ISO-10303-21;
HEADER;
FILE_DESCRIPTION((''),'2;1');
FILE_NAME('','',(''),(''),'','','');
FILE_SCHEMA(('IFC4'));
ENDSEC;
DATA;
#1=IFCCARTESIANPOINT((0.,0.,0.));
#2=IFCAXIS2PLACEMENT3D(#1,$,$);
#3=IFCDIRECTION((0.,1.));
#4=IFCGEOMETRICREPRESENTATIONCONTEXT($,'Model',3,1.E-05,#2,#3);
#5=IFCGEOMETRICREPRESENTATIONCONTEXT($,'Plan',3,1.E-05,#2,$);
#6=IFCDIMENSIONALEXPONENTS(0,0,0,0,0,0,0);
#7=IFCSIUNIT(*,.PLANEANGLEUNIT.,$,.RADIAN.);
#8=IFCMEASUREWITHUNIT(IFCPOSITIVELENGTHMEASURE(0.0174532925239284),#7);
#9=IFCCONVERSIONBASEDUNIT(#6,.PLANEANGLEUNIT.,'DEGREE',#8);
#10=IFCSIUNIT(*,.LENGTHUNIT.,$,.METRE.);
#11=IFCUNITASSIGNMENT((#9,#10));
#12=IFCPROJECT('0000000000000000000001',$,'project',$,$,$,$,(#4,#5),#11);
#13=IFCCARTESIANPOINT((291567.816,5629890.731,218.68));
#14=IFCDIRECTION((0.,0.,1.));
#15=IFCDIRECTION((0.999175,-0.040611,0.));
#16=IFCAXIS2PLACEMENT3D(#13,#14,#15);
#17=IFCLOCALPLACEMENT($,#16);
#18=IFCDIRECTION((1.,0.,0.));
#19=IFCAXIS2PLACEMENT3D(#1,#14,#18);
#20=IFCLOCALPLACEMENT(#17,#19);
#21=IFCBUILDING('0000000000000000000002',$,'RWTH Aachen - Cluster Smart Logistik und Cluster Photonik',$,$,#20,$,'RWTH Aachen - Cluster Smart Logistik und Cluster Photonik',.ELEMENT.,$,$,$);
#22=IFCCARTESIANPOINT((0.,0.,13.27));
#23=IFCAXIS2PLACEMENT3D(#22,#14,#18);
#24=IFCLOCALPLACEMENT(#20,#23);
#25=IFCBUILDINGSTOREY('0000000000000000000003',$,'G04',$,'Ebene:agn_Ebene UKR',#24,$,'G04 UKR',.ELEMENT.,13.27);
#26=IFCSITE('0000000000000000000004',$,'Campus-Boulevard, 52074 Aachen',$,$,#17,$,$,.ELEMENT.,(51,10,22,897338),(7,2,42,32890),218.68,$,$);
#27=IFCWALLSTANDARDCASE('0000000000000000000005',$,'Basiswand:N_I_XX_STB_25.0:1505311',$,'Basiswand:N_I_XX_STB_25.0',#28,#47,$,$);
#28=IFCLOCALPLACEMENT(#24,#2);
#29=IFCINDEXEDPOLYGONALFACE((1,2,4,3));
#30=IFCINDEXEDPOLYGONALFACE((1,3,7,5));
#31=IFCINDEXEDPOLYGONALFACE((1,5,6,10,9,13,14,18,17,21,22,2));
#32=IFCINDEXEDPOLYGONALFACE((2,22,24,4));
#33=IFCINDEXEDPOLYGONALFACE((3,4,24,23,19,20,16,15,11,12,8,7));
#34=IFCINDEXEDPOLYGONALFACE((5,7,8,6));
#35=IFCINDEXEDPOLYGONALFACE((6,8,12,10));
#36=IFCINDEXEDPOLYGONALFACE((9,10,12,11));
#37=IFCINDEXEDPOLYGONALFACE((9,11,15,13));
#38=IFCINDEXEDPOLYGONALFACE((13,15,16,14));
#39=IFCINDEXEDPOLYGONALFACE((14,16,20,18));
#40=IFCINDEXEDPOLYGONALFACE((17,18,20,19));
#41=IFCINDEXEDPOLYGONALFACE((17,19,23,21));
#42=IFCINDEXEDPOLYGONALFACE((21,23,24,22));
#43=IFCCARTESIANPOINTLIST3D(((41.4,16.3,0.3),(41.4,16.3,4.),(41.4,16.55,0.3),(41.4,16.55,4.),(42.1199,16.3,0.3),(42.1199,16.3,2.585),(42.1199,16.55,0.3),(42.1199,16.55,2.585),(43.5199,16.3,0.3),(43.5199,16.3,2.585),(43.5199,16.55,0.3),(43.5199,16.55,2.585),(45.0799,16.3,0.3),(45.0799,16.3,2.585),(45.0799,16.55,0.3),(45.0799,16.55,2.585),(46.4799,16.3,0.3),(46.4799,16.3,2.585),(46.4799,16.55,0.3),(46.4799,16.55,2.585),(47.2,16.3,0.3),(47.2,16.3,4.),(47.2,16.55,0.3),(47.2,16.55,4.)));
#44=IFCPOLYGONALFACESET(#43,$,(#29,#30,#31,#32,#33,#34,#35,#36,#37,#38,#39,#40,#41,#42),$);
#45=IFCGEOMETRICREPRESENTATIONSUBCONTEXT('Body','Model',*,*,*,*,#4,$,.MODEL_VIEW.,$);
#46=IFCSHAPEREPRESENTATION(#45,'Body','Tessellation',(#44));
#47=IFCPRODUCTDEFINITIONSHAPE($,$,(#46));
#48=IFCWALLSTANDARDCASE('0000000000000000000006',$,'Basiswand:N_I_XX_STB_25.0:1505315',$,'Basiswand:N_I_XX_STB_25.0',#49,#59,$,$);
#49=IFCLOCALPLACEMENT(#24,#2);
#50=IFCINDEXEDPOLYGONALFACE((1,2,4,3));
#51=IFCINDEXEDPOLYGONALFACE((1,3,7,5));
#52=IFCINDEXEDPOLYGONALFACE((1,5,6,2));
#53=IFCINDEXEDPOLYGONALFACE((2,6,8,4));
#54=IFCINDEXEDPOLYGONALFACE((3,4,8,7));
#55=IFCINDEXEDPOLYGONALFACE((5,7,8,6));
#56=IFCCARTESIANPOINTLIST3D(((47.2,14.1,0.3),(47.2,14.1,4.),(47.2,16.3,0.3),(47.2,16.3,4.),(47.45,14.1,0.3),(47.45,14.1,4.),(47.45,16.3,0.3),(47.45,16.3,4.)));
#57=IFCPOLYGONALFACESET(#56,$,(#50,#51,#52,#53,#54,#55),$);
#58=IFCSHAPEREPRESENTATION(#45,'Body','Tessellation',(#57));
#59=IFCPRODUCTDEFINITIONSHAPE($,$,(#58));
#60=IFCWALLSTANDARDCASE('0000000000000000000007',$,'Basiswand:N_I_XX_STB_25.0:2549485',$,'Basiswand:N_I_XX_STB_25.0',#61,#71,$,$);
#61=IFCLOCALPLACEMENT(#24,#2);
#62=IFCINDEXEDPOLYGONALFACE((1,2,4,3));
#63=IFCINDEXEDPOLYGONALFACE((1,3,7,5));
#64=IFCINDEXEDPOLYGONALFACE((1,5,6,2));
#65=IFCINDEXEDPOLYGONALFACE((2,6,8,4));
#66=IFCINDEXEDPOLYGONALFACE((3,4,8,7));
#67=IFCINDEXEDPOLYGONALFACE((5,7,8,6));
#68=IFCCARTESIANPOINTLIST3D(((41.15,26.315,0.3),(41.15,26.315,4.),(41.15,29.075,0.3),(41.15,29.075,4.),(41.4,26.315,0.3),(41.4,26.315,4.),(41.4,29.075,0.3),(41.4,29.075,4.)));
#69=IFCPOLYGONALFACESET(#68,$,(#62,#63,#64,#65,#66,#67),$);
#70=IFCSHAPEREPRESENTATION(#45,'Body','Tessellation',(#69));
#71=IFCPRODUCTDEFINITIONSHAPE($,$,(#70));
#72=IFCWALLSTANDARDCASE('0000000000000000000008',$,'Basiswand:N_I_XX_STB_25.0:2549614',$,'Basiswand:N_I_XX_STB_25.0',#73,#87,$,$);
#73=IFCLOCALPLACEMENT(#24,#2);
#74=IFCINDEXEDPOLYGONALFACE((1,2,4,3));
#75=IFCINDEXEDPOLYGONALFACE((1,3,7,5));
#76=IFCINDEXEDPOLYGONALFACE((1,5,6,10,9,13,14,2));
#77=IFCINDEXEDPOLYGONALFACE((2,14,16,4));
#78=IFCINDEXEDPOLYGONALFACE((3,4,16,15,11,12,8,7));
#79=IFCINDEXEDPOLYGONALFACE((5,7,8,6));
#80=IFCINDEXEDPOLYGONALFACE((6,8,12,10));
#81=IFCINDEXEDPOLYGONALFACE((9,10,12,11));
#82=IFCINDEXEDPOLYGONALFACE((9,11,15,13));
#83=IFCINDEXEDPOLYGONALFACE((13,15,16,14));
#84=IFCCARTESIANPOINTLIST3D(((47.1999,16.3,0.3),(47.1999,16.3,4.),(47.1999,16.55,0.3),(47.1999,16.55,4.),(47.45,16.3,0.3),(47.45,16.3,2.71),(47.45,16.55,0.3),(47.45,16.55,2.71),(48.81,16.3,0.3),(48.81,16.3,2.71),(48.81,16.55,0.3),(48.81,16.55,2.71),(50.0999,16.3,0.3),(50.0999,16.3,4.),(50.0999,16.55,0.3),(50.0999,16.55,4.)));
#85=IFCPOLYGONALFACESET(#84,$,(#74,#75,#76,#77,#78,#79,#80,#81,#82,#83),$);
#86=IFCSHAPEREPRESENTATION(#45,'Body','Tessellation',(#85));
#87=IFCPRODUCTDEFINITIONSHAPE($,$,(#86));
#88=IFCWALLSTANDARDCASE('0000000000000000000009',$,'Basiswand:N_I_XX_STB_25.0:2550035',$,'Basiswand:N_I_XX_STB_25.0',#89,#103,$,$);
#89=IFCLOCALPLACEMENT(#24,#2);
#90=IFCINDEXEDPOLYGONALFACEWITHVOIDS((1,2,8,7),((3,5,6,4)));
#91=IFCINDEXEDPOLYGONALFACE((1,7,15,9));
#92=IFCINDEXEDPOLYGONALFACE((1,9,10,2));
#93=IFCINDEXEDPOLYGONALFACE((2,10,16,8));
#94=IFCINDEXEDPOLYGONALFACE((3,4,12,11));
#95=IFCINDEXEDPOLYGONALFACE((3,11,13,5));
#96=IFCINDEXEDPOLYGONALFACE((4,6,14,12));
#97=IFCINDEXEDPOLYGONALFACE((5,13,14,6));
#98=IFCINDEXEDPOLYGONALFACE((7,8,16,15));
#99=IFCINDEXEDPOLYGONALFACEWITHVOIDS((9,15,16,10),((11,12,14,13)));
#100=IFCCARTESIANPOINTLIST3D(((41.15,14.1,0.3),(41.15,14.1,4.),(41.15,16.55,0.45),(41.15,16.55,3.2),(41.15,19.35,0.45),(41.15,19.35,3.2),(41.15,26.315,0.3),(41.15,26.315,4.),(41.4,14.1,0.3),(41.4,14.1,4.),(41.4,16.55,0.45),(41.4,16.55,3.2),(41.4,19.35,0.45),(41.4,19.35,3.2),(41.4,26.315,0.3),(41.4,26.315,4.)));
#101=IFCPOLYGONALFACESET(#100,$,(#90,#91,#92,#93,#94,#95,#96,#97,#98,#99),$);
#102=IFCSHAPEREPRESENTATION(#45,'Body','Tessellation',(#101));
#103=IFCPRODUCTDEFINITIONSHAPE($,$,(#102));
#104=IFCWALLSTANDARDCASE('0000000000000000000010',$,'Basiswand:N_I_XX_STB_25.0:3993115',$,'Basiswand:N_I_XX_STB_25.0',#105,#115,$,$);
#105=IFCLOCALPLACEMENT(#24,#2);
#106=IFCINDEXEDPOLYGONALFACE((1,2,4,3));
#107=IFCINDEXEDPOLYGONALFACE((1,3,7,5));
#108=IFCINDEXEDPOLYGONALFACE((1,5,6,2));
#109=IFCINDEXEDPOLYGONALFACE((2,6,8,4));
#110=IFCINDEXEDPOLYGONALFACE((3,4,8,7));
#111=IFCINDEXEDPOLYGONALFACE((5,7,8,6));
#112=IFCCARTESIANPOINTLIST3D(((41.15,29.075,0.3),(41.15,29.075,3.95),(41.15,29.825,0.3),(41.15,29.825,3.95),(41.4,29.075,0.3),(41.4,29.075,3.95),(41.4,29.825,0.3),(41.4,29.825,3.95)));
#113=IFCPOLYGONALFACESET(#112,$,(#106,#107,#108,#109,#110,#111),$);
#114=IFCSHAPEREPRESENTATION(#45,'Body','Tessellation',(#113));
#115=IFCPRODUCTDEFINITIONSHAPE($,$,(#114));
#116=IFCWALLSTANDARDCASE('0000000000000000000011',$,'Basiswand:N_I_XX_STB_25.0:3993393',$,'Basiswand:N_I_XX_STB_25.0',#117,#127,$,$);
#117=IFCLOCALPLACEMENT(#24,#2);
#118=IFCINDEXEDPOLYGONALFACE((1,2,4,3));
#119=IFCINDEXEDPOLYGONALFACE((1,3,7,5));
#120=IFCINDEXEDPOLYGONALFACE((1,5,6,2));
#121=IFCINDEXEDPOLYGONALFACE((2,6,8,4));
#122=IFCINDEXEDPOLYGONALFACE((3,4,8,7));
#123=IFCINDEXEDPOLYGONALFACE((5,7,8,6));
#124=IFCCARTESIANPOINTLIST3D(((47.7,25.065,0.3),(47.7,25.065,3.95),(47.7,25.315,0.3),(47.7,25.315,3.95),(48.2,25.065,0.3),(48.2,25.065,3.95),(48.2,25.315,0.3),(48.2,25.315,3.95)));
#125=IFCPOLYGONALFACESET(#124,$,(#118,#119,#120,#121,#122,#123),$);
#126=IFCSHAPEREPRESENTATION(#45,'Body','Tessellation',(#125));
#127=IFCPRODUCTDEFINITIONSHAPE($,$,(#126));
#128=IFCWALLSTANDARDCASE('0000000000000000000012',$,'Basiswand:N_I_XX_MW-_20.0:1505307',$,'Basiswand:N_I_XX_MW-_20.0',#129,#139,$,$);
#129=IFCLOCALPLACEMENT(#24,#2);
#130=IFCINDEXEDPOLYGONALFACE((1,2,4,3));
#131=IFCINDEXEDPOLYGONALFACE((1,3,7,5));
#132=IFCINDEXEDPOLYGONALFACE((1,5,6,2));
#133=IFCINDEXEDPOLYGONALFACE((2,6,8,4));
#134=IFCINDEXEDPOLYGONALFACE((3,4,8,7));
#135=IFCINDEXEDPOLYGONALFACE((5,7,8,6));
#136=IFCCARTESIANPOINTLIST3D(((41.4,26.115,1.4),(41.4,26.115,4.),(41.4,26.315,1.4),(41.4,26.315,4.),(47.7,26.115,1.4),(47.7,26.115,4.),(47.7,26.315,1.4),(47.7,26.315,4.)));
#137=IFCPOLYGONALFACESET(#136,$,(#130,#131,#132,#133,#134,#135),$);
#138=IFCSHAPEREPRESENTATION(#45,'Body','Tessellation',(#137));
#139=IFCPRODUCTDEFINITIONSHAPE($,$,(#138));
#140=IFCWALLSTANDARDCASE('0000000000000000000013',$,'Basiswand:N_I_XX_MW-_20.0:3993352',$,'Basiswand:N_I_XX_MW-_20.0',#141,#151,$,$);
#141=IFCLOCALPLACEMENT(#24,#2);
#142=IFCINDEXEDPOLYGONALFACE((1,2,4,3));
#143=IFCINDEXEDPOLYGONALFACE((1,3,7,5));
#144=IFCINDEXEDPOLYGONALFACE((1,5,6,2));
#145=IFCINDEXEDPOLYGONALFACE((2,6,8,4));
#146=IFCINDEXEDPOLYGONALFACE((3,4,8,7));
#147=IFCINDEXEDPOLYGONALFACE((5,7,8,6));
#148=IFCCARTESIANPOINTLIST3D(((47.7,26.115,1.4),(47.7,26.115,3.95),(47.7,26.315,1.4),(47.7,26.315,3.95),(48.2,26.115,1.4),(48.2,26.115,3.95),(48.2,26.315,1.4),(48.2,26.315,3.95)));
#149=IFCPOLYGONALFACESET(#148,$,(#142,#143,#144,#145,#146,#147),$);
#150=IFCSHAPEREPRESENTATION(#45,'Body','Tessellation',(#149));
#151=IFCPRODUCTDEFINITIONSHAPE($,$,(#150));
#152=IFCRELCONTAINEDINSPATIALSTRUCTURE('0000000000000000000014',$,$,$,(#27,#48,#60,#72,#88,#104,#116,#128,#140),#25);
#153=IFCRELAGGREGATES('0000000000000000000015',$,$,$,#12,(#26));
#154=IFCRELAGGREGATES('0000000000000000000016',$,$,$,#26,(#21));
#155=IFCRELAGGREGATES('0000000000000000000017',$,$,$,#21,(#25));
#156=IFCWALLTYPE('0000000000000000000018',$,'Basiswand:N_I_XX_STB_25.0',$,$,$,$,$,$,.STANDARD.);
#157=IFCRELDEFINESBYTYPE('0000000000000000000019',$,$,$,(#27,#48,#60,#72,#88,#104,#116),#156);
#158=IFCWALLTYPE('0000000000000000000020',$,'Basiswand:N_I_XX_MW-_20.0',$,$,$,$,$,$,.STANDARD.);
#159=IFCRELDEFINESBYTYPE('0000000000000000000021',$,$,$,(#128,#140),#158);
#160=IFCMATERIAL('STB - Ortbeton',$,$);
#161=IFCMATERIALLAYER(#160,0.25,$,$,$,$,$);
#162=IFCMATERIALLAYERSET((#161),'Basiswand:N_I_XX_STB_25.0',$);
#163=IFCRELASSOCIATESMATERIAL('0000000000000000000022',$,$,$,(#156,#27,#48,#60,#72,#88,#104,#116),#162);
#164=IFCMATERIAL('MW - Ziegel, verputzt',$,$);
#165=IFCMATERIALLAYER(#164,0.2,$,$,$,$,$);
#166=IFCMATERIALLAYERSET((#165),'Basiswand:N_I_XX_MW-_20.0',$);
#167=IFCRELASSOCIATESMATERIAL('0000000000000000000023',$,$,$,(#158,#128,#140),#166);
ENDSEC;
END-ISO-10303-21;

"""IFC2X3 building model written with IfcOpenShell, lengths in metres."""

from ifc_helpers import new_model, entity, si_unit, converted_unit, direction, frame, frame_2d, origin, origin_with_axes, place, context, subcontext, project, spatial, rectangle, extrude, material, layer, layer_set, layer_usage, type_object, element, save


model = new_model("IFC2X3")

# Units and contexts
model_context = context("Model", 3, precision=1e-05, world=origin(), true_north=direction((0.0, 1.0)))
plan_context = context("Plan", 3, precision=1e-05, world=origin())
body_context = subcontext(model_context, "Body", "Model", "MODEL_VIEW")
ifc_project = project(units=[converted_unit("PLANEANGLEUNIT", "DEGREE", entity("IfcPositiveLengthMeasure", 0.0174532925239284), si_unit("PLANEANGLEUNIT", "RADIAN"), dimensions=[0, 0, 0, 0, 0, 0, 0]), si_unit("LENGTHUNIT", "METRE")], contexts=[model_context, plan_context])

# Site, building, storey
site_placement = place(None, frame((291567.816, 5629890.731, 218.68), z_axis=(0.0, 0.0, 1.0), x_axis=(0.999175, -0.040611, 0.0)))
site = spatial("IfcSite", under=ifc_project, at=site_placement, Name="Campus-Boulevard, 52074 Aachen", CompositionType="ELEMENT", RefLatitude=(51, 10, 22, 897338), RefLongitude=(7, 2, 42, 32890), RefElevation=218.68)
building_placement = place(site_placement, origin_with_axes())
building = spatial("IfcBuilding", under=site, at=building_placement, Name="RWTH Aachen - Cluster Smart Logistik und Cluster Photonik", LongName="RWTH Aachen - Cluster Smart Logistik und Cluster Photonik", CompositionType="ELEMENT")
storey_placement = place(building_placement, frame((0.0, 0.0, 13.27), z_axis=(0.0, 0.0, 1.0), x_axis=(1.0, 0.0, 0.0)))
storey = spatial("IfcBuildingStorey", under=building, at=storey_placement, Name="G04", ObjectType="Ebene:agn_Ebene UKR", LongName="G04 UKR", CompositionType="ELEMENT", Elevation=13.27)

# Shared definitions
ifc_material_1 = material(Name="STB - Ortbeton")

# Shared definitions
ifc_layer_1 = layer(ifc_material_1, 0.25)
ifc_layer_set_1 = layer_set([ifc_layer_1], Name="Basiswand:N_I_XX_STB_25.0")
wall_type_1 = type_object("IfcWallType", Name="Basiswand:N_I_XX_STB_25.0", PredefinedType="STANDARD", material=ifc_layer_set_1)

# Wall, openings
ifc_layer_usage_1 = layer_usage(ifc_layer_set_1, "AXIS2", "NEGATIVE", 0.125)
wall_1_placement = place(storey_placement, frame((41.4, 16.425, 0.3), z_axis=(0.0, 0.0, 1.0), x_axis=(1.0, 0.0, 0.0)))
wall_1 = element("IfcWallStandardCase", 1, at=wall_1_placement, inside=storey, type_object=wall_type_1, material=ifc_layer_usage_1, Name="Basiswand:N_I_XX_STB_25.0:1505311", ObjectType="Basiswand:N_I_XX_STB_25.0", context=body_context, shape_type="SweptSolid", body=[
    extrude(rectangle(XDim=5.8, YDim=0.25, at=frame_2d((2.9, 0.0), x_axis=(-1.0, 0.0))), origin(), (0.0, 0.0, 1.0), 3.7),
])
opening_1_placement = place(wall_1_placement, frame((2.1199, 0.125, 0.0), z_axis=(0.0, 0.0, 1.0), x_axis=(1.0, 0.0, 0.0)))
element("IfcOpeningElement", 2, at=opening_1_placement, cuts=wall_1, ObjectType="Opening", context=body_context, shape_type="SweptSolid", body=[
    extrude(rectangle(XDim=2.285, YDim=1.4, at=frame_2d((1.1425, 0.7), x_axis=(1.0, 0.0))), frame((0.0, 0.0, 0.0), z_axis=(0.0, -1.0, 0.0), x_axis=(0.0, 0.0, 1.0)), (0.0, 0.0, 1.0), 0.25),
])
opening_2_placement = place(wall_1_placement, frame((5.0799, 0.125, 0.0), z_axis=(0.0, 0.0, 1.0), x_axis=(1.0, 0.0, 0.0)))
element("IfcOpeningElement", 3, at=opening_2_placement, cuts=wall_1, ObjectType="Opening", context=body_context, shape_type="SweptSolid", body=[
    extrude(rectangle(XDim=2.285, YDim=1.4, at=frame_2d((1.1425, 0.7), x_axis=(1.0, 0.0))), frame((0.0, 0.0, 0.0), z_axis=(0.0, -1.0, 0.0), x_axis=(0.0, 0.0, 1.0)), (0.0, 0.0, 1.0), 0.25),
])

# Walls
ifc_layer_usage_2 = layer_usage(ifc_layer_set_1, "AXIS2", "NEGATIVE", 0.125)
wall_2_placement = place(storey_placement, frame((47.325, 16.3, 0.3), z_axis=(0.0, 0.0, 1.0), x_axis=(0.0, -1.0, 0.0)))
element("IfcWallStandardCase", 4, at=wall_2_placement, inside=storey, type_object=wall_type_1, material=ifc_layer_usage_2, Name="Basiswand:N_I_XX_STB_25.0:1505315", ObjectType="Basiswand:N_I_XX_STB_25.0", context=body_context, shape_type="SweptSolid", body=[
    extrude(rectangle(XDim=2.2, YDim=0.25, at=frame_2d((1.1, 0.0), x_axis=(-1.0, 0.0))), origin(), (0.0, 0.0, 1.0), 3.7),
])
ifc_layer_usage_3 = layer_usage(ifc_layer_set_1, "AXIS2", "NEGATIVE", 0.125)
wall_3_placement = place(storey_placement, frame((41.275, 26.315, 0.3), z_axis=(0.0, 0.0, 1.0), x_axis=(0.0, 1.0, 0.0)))
element("IfcWallStandardCase", 5, at=wall_3_placement, inside=storey, type_object=wall_type_1, material=ifc_layer_usage_3, Name="Basiswand:N_I_XX_STB_25.0:2549485", ObjectType="Basiswand:N_I_XX_STB_25.0", context=body_context, shape_type="SweptSolid", body=[
    extrude(rectangle(XDim=2.76, YDim=0.25, at=frame_2d((1.38, 0.0), x_axis=(-1.0, 0.0))), origin(), (0.0, 0.0, 1.0), 3.7),
])

# Walls, openings
ifc_layer_usage_4 = layer_usage(ifc_layer_set_1, "AXIS2", "NEGATIVE", 0.125)
wall_4_placement = place(storey_placement, frame((47.1999, 16.425, 0.3), z_axis=(0.0, 0.0, 1.0), x_axis=(1.0, 0.0, 0.0)))
wall_4 = element("IfcWallStandardCase", 6, at=wall_4_placement, inside=storey, type_object=wall_type_1, material=ifc_layer_usage_4, Name="Basiswand:N_I_XX_STB_25.0:2549614", ObjectType="Basiswand:N_I_XX_STB_25.0", context=body_context, shape_type="SweptSolid", body=[
    extrude(rectangle(XDim=2.9, YDim=0.25, at=frame_2d((1.45, 0.0), x_axis=(-1.0, 0.0))), origin(), (0.0, 0.0, 1.0), 3.7),
])
opening_3_placement = place(wall_4_placement, frame((1.6101, 0.125, 0.0), z_axis=(0.0, 0.0, 1.0), x_axis=(1.0, 0.0, 0.0)))
element("IfcOpeningElement", 7, at=opening_3_placement, cuts=wall_4, ObjectType="Opening", context=body_context, shape_type="SweptSolid", body=[
    extrude(rectangle(XDim=2.41, YDim=1.36, at=frame_2d((1.205, 0.68), x_axis=(1.0, 0.0))), frame((0.0, 0.0, 0.0), z_axis=(0.0, -1.0, 0.0), x_axis=(0.0, 0.0, 1.0)), (0.0, 0.0, 1.0), 0.25),
])
ifc_layer_usage_5 = layer_usage(ifc_layer_set_1, "AXIS2", "NEGATIVE", 0.125)
wall_5_placement = place(storey_placement, frame((41.275, 14.1, 0.3), z_axis=(0.0, 0.0, 1.0), x_axis=(0.0, 1.0, 0.0)))
wall_5 = element("IfcWallStandardCase", 8, at=wall_5_placement, inside=storey, type_object=wall_type_1, material=ifc_layer_usage_5, Name="Basiswand:N_I_XX_STB_25.0:2550035", ObjectType="Basiswand:N_I_XX_STB_25.0", context=body_context, shape_type="SweptSolid", body=[
    extrude(rectangle(XDim=12.215, YDim=0.25, at=frame_2d((6.1075, 0.0), x_axis=(-1.0, 0.0))), origin(), (0.0, 0.0, 1.0), 3.7),
])
opening_4_placement = place(wall_5_placement, frame((2.45, 0.2774, 0.15), z_axis=(0.0, 0.0, 1.0), x_axis=(1.0, 0.0, 0.0)))
element("IfcOpeningElement", 9, at=opening_4_placement, cuts=wall_5, ObjectType="Opening", context=body_context, shape_type="SweptSolid", body=[
    extrude(rectangle(XDim=2.75, YDim=2.8, at=frame_2d((0.0, 0.0), x_axis=(0.0, 1.0))), frame((1.4, -0.5548, 1.375), z_axis=(0.0, 1.0, 0.0), x_axis=(-1.0, 0.0, 0.0)), (0.0, 0.0, 1.0), 0.5548),
])

# Walls
ifc_layer_usage_6 = layer_usage(ifc_layer_set_1, "AXIS2", "NEGATIVE", 0.125)
wall_6_placement = place(storey_placement, frame((41.275, 29.075, 0.3), z_axis=(0.0, 0.0, 1.0), x_axis=(0.0, 1.0, 0.0)))
element("IfcWallStandardCase", 10, at=wall_6_placement, inside=storey, type_object=wall_type_1, material=ifc_layer_usage_6, Name="Basiswand:N_I_XX_STB_25.0:3993115", ObjectType="Basiswand:N_I_XX_STB_25.0", context=body_context, shape_type="SweptSolid", body=[
    extrude(rectangle(XDim=0.75, YDim=0.25, at=frame_2d((0.375, 0.0), x_axis=(-1.0, 0.0))), origin(), (0.0, 0.0, 1.0), 3.65),
])
ifc_layer_usage_7 = layer_usage(ifc_layer_set_1, "AXIS2", "NEGATIVE", 0.125)
wall_7_placement = place(storey_placement, frame((47.7, 25.19, 0.3), z_axis=(0.0, 0.0, 1.0), x_axis=(1.0, 0.0, 0.0)))
element("IfcWallStandardCase", 11, at=wall_7_placement, inside=storey, type_object=wall_type_1, material=ifc_layer_usage_7, Name="Basiswand:N_I_XX_STB_25.0:3993393", ObjectType="Basiswand:N_I_XX_STB_25.0", context=body_context, shape_type="SweptSolid", body=[
    extrude(rectangle(XDim=0.5, YDim=0.25, at=frame_2d((0.25, 0.0), x_axis=(-1.0, 0.0))), origin(), (0.0, 0.0, 1.0), 3.65),
])
ifc_material_2 = material(Name="MW - Ziegel, verputzt")
ifc_layer_2 = layer(ifc_material_2, 0.2)
ifc_layer_set_2 = layer_set([ifc_layer_2], Name="Basiswand:N_I_XX_MW-_20.0")
ifc_layer_usage_8 = layer_usage(ifc_layer_set_2, "AXIS2", "NEGATIVE", 0.1)
wall_type_2 = type_object("IfcWallType", Name="Basiswand:N_I_XX_MW-_20.0", PredefinedType="STANDARD", material=ifc_layer_set_2)
wall_8_placement = place(storey_placement, frame((41.4, 26.215, 1.4), z_axis=(0.0, 0.0, 1.0), x_axis=(1.0, 0.0, 0.0)))
element("IfcWallStandardCase", 12, at=wall_8_placement, inside=storey, type_object=wall_type_2, material=ifc_layer_usage_8, Name="Basiswand:N_I_XX_MW-_20.0:1505307", ObjectType="Basiswand:N_I_XX_MW-_20.0", context=body_context, shape_type="SweptSolid", body=[
    extrude(rectangle(XDim=6.3, YDim=0.2, at=frame_2d((3.15, 0.0), x_axis=(-1.0, 0.0))), origin(), (0.0, 0.0, 1.0), 2.6),
])
ifc_layer_usage_9 = layer_usage(ifc_layer_set_2, "AXIS2", "NEGATIVE", 0.1)
wall_9_placement = place(storey_placement, frame((47.7, 26.215, 1.4), z_axis=(0.0, 0.0, 1.0), x_axis=(1.0, 0.0, 0.0)))
element("IfcWallStandardCase", 13, at=wall_9_placement, inside=storey, type_object=wall_type_2, material=ifc_layer_usage_9, Name="Basiswand:N_I_XX_MW-_20.0:3993352", ObjectType="Basiswand:N_I_XX_MW-_20.0", context=body_context, shape_type="SweptSolid", body=[
    extrude(rectangle(XDim=0.5, YDim=0.2, at=frame_2d((0.25, 0.0), x_axis=(-1.0, 0.0))), origin(), (0.0, 0.0, 1.0), 2.55),
])

save(model, "model.ifc")
